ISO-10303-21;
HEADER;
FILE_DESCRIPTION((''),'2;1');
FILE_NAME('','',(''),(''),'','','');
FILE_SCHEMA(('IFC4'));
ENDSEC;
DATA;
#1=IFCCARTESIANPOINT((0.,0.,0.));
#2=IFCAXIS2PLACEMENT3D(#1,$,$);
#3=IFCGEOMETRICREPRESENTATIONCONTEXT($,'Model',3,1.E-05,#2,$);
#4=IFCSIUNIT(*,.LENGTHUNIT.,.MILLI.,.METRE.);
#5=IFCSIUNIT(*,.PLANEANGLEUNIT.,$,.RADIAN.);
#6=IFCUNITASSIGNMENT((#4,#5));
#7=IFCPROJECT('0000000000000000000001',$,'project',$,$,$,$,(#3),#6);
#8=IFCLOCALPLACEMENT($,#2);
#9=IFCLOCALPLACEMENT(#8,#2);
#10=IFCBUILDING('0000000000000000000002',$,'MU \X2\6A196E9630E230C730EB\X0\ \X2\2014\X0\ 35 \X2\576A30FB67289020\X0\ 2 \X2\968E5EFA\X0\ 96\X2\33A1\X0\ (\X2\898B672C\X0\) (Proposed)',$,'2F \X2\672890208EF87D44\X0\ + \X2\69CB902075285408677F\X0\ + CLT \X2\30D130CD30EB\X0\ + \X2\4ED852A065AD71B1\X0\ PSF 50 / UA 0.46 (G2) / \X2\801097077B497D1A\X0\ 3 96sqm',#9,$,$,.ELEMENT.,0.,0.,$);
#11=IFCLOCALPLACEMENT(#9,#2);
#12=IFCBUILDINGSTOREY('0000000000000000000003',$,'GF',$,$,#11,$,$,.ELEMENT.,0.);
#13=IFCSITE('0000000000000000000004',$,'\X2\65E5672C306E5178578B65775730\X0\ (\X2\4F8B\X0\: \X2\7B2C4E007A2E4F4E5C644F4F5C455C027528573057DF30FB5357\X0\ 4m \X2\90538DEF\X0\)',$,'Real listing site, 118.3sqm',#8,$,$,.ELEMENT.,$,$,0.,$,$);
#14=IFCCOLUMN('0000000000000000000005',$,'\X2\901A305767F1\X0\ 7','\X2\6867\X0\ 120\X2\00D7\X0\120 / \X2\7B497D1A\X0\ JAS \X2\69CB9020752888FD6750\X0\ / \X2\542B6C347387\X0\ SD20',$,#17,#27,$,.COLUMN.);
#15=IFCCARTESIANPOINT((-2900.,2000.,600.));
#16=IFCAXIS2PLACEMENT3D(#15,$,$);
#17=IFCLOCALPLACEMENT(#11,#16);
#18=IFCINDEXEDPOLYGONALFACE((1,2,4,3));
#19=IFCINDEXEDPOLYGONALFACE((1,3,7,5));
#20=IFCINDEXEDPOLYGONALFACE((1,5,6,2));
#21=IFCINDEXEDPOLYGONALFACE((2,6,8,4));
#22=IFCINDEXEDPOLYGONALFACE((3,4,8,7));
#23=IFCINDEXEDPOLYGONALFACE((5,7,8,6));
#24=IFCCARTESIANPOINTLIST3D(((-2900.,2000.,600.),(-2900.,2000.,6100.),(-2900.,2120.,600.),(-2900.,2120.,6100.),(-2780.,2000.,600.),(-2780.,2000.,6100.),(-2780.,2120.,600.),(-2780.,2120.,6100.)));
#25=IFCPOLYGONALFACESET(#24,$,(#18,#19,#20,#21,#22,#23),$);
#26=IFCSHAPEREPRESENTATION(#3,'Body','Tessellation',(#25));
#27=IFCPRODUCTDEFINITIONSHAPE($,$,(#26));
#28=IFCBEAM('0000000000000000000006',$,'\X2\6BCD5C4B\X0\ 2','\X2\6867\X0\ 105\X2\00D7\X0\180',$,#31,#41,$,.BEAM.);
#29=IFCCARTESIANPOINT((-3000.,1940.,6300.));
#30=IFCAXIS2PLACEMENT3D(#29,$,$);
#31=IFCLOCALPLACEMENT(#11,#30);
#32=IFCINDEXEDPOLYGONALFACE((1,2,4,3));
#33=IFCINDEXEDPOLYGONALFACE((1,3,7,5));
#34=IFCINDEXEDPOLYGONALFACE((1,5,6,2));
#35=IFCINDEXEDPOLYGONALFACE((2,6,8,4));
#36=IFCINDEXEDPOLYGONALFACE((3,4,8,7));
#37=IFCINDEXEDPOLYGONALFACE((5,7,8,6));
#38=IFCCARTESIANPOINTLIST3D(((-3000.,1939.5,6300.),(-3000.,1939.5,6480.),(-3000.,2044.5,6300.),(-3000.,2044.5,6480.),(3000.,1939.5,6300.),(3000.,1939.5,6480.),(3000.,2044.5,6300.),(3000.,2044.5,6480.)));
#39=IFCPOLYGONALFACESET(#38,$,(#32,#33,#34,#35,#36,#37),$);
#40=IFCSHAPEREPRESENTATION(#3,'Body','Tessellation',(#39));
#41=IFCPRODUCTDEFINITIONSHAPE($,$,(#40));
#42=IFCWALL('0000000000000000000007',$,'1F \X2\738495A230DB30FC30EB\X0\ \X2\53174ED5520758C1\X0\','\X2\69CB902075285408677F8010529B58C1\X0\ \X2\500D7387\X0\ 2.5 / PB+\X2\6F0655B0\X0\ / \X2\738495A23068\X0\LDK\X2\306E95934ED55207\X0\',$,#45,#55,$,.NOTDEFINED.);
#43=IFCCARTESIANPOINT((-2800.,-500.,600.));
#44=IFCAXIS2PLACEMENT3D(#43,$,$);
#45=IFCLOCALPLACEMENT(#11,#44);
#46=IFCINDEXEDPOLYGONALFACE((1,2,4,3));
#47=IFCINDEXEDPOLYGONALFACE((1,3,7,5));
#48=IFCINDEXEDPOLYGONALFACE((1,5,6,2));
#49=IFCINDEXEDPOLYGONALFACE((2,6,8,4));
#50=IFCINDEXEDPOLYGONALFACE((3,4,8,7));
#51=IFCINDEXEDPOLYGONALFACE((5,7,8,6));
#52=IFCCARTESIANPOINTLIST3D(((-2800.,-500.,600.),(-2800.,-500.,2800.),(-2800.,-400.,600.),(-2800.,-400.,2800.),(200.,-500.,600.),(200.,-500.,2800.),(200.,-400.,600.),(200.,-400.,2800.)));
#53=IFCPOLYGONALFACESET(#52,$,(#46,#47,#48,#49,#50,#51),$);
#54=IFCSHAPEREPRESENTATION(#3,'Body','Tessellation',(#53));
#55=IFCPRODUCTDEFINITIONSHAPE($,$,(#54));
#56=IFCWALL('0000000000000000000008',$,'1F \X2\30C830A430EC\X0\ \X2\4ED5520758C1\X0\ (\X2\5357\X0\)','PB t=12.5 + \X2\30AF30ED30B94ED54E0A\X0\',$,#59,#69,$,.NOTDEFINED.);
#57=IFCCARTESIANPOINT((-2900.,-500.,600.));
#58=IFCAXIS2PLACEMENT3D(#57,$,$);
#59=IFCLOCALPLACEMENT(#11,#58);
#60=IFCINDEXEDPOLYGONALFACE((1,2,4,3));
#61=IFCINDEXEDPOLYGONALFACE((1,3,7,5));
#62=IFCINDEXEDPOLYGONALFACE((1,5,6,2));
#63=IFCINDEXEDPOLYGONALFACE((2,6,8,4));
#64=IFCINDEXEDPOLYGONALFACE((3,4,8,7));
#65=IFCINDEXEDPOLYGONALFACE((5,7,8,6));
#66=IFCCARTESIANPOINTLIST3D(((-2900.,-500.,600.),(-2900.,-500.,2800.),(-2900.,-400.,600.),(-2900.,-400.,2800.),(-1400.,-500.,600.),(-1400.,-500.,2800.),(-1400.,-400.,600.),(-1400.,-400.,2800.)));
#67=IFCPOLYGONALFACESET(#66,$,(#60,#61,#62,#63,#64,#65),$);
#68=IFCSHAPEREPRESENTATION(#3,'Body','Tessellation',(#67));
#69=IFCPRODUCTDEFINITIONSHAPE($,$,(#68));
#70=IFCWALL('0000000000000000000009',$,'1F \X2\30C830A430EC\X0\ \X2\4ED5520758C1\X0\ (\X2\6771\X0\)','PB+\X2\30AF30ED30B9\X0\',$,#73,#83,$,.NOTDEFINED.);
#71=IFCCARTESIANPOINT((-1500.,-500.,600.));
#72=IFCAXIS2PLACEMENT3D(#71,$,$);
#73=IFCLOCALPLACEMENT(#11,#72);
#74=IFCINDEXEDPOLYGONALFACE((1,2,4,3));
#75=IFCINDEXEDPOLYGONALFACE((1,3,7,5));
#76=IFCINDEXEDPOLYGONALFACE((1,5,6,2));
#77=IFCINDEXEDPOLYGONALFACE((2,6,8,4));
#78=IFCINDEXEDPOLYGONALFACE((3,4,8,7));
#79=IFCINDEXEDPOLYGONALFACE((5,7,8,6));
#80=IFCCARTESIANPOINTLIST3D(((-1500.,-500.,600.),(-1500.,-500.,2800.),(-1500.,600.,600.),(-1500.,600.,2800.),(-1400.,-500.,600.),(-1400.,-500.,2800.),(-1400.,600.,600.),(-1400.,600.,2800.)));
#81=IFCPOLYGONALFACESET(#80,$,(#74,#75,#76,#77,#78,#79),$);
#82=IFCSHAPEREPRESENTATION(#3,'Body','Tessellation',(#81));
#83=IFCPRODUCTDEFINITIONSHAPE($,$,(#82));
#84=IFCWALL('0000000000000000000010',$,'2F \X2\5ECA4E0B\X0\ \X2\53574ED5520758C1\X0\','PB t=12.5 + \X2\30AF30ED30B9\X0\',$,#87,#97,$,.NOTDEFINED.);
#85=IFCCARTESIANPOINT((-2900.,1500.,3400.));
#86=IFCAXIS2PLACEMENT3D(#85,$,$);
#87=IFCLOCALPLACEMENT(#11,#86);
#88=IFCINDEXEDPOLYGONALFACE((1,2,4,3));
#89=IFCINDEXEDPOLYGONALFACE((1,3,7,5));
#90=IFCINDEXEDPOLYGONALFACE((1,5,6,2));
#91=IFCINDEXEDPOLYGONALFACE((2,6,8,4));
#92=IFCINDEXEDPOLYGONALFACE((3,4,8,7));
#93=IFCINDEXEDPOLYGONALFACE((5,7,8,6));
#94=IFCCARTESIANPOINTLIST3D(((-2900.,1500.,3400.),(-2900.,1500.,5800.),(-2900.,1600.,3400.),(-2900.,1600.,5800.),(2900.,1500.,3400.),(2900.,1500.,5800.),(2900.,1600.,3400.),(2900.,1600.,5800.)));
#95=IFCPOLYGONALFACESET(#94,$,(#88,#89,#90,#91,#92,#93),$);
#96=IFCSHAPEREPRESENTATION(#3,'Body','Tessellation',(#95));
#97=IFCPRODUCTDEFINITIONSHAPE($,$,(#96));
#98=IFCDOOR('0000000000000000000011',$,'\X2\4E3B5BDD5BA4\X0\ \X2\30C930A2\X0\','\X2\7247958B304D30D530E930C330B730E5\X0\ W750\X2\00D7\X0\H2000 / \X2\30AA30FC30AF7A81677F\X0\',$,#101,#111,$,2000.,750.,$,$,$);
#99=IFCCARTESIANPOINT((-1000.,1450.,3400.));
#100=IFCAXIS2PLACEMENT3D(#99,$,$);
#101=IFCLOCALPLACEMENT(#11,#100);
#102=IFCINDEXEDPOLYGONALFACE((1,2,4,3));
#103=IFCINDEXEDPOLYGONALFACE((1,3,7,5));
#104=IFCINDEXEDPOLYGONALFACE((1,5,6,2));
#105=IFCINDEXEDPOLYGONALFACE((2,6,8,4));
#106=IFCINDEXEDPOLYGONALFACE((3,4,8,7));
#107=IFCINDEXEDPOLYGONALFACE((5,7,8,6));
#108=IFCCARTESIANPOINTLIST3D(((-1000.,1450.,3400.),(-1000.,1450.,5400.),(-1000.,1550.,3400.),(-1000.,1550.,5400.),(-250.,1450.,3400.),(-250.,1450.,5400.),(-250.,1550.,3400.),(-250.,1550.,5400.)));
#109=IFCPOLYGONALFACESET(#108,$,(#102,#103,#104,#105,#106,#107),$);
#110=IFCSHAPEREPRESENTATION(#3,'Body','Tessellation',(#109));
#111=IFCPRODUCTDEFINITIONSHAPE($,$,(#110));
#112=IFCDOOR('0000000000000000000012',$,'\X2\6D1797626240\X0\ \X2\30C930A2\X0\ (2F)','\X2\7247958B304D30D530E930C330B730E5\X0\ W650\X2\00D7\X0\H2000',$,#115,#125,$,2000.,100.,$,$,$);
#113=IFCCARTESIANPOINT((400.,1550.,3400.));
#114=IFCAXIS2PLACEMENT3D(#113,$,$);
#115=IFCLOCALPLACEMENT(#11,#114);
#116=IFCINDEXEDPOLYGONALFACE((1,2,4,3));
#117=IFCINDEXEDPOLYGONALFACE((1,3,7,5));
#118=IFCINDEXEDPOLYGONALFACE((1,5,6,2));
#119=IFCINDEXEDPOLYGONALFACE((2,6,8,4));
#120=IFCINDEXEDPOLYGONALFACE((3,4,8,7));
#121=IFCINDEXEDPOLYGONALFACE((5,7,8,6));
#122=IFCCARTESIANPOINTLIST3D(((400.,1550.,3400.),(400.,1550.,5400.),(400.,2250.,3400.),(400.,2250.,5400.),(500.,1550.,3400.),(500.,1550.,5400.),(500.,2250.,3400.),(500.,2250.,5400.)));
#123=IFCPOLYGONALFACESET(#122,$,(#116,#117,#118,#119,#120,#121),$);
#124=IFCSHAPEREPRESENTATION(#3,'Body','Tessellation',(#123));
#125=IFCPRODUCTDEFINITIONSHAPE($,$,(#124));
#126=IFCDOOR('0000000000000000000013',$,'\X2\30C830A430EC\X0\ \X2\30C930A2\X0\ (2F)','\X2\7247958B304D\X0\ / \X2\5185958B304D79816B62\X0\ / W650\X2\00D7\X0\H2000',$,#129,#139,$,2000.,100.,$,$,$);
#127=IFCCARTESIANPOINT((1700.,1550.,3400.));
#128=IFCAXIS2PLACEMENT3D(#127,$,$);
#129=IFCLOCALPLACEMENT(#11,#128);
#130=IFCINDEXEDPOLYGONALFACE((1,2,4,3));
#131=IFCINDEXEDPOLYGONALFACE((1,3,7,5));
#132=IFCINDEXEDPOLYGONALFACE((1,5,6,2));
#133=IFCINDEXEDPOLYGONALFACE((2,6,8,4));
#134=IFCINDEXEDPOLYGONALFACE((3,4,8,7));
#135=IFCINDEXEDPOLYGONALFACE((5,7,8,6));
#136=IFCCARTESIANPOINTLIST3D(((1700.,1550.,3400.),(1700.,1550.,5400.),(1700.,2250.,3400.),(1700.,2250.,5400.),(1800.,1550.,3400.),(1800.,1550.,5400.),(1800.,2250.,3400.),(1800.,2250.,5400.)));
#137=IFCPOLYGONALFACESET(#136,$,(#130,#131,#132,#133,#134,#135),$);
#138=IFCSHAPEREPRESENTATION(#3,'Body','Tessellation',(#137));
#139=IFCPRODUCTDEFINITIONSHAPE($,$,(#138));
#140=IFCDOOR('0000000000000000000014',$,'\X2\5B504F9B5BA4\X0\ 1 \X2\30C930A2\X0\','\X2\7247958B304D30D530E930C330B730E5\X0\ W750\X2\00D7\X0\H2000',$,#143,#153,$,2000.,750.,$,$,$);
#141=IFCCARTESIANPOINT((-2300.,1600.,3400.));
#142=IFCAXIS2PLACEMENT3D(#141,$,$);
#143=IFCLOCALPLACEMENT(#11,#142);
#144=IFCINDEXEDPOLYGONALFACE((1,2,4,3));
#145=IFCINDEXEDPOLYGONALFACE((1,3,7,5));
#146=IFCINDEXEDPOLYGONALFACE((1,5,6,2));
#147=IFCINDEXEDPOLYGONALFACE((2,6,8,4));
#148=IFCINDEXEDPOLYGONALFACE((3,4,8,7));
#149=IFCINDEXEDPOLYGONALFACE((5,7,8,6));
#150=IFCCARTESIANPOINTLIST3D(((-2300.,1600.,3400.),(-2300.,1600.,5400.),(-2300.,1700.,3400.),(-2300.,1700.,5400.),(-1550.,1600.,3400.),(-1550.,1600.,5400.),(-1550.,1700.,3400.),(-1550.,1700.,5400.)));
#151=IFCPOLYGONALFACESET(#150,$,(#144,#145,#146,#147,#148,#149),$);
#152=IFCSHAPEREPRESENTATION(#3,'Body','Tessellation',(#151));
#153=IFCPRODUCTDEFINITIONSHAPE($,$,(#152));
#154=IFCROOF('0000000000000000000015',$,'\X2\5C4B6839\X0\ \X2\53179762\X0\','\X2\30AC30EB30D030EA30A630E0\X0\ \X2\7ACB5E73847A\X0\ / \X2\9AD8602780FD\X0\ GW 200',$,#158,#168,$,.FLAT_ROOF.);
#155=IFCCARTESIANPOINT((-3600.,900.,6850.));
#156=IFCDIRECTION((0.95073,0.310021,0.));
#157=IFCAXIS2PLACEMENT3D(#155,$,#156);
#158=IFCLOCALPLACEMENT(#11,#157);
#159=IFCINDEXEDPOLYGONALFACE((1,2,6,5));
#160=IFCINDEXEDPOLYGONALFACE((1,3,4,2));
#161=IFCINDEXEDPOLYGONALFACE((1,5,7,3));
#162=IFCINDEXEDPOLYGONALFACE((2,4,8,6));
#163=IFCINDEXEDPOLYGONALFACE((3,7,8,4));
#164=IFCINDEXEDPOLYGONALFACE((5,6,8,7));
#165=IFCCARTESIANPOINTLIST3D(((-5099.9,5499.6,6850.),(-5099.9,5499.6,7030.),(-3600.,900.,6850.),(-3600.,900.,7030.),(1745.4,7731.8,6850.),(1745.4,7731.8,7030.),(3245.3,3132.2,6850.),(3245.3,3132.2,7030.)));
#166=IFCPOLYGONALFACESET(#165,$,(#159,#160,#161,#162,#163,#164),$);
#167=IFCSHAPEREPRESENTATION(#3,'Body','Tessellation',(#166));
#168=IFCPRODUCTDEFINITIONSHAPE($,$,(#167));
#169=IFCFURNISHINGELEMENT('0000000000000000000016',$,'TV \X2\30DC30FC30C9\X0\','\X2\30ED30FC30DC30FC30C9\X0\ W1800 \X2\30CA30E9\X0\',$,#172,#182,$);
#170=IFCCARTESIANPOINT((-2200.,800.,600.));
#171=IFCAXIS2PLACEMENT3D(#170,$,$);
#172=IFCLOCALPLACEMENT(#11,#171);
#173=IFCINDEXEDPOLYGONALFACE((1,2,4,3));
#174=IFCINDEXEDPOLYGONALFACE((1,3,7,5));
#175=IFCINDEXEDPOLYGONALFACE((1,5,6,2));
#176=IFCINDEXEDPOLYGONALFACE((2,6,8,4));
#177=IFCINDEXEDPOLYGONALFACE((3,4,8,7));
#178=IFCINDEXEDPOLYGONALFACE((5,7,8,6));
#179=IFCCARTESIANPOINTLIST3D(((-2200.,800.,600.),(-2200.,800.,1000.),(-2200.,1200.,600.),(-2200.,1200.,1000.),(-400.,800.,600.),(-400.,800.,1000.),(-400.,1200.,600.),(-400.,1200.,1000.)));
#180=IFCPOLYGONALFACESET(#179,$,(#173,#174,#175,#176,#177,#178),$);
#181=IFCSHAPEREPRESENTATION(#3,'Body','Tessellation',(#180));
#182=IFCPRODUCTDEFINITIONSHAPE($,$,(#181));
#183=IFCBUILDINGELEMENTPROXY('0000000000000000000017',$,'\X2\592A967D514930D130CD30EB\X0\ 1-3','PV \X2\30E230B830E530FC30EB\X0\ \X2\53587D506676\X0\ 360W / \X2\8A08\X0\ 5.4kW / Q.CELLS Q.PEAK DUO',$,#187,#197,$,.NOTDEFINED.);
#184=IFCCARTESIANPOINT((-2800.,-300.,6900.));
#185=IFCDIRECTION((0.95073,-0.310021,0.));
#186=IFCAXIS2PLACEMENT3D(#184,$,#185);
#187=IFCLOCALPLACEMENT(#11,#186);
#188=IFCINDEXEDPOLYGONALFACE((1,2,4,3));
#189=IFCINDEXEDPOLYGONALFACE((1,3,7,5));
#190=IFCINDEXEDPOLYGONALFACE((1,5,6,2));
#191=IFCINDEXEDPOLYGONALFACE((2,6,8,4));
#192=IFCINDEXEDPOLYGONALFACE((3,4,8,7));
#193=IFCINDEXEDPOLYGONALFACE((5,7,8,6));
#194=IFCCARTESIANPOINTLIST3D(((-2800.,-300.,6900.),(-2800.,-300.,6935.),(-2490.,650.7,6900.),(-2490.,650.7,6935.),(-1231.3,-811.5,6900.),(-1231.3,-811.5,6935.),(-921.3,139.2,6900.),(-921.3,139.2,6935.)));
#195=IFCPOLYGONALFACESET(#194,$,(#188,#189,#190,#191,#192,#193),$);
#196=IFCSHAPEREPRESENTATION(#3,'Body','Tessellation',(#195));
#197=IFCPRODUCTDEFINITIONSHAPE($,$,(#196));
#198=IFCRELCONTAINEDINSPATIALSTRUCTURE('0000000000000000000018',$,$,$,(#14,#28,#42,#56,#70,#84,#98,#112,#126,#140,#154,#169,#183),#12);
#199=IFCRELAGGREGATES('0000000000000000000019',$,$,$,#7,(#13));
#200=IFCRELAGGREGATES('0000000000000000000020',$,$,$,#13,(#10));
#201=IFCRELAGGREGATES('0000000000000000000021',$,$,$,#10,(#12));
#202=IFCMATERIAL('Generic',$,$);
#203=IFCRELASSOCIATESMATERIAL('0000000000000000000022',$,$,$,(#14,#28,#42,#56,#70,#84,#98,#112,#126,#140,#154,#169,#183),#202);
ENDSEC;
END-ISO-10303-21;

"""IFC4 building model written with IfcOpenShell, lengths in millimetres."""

from ifc_helpers import new_model, si_unit, frame, frame_2d, origin, place, context, project, spatial, rectangle, extrude, material, element, fill, save


model = new_model("IFC4")

# Units and contexts
model_context = context("Model", 3, precision=1e-05, world=origin())
ifc_project = project(units=[si_unit("LENGTHUNIT", "METRE", prefix="MILLI"), si_unit("PLANEANGLEUNIT", "RADIAN")], contexts=[model_context])

# Site, building, storey
site_placement = place(None, origin())
site = spatial("IfcSite", under=ifc_project, at=site_placement, Name="日本の典型敷地 (例: 第一種低層住居専用地域・南 4m 道路)", ObjectType="Real listing site, 118.3sqm", CompositionType="ELEMENT", RefElevation=0.0)
building_placement = place(site_placement, origin())
building = spatial("IfcBuilding", under=site, at=building_placement, Name="MU 標準モデル — 35 坪・木造 2 階建 96㎡ (見本) (Proposed)", ObjectType="2F 木造軸組 + 構造用合板 + CLT パネル + 付加断熱 PSF 50 / UA 0.46 (G2) / 耐震等級 3 96sqm", CompositionType="ELEMENT", ElevationOfRefHeight=0.0, ElevationOfTerrain=0.0)
storey_placement = place(building_placement, origin())
storey = spatial("IfcBuildingStorey", under=building, at=storey_placement, Name="GF", CompositionType="ELEMENT", Elevation=0.0)

# Column
ifc_material_1 = material(Name="Generic")
column_placement = place(storey_placement, frame((-2900.0, 2000.0, 600.0)))
element("IfcColumn", 1, at=column_placement, inside=storey, material=ifc_material_1, Name="通し柱 7", Description="桧 120×120 / 等級 JAS 構造用製材 / 含水率 SD20", PredefinedType="COLUMN", context=model_context, shape_type="SweptSolid", body=[
    extrude(rectangle(XDim=120.0, YDim=120.0, at=frame_2d((60.0, 60.0))), frame((-2900.0, 2000.0, 600.0)), (0.0, 0.0, 1.0), 5500.0),
])

# Beam
beam_1_placement = place(storey_placement, frame((-3000.0, 1940.0, 6300.0)))
element("IfcBeam", 2, at=beam_1_placement, inside=storey, material=ifc_material_1, Name="母屋 2", Description="桧 105×180", PredefinedType="BEAM", context=model_context, shape_type="SweptSolid", body=[
    extrude(rectangle(XDim=6000.0, YDim=105.0, at=frame_2d((3000.0, 52.0))), frame((-3000.0, 1940.0, 6300.0)), (0.0, 0.0, 1.0), 180.0),
])

# Walls
wall_1_placement = place(storey_placement, frame((-2800.0, -500.0, 600.0)))
element("IfcWall", 3, at=wall_1_placement, inside=storey, material=ifc_material_1, Name="1F 玄関ホール 北仕切壁", Description="構造用合板耐力壁 倍率 2.5 / PB+漆喰 / 玄関とLDKの間仕切", PredefinedType="NOTDEFINED", context=model_context, shape_type="SweptSolid", body=[
    extrude(rectangle(XDim=3000.0, YDim=100.0, at=frame_2d((1500.0, 50.0))), frame((-2800.0, -500.0, 600.0)), (0.0, 0.0, 1.0), 2200.0),
])
wall_2_placement = place(storey_placement, frame((-2900.0, -500.0, 600.0)))
element("IfcWall", 4, at=wall_2_placement, inside=storey, material=ifc_material_1, Name="1F トイレ 仕切壁 (南)", Description="PB t=12.5 + クロス仕上", PredefinedType="NOTDEFINED", context=model_context, shape_type="SweptSolid", body=[
    extrude(rectangle(XDim=1500.0, YDim=100.0, at=frame_2d((750.0, 50.0))), frame((-2900.0, -500.0, 600.0)), (0.0, 0.0, 1.0), 2200.0),
])
wall_3_placement = place(storey_placement, frame((-1500.0, -500.0, 600.0)))
element("IfcWall", 5, at=wall_3_placement, inside=storey, material=ifc_material_1, Name="1F トイレ 仕切壁 (東)", Description="PB+クロス", PredefinedType="NOTDEFINED", context=model_context, shape_type="SweptSolid", body=[
    extrude(rectangle(XDim=100.0, YDim=1100.0, at=frame_2d((50.0, 550.0))), frame((-1500.0, -500.0, 600.0)), (0.0, 0.0, 1.0), 2200.0),
])

# Wall, openings, doors
wall_4_placement = place(storey_placement, frame((-2900.0, 1500.0, 3400.0)))
wall_4 = element("IfcWall", 6, at=wall_4_placement, inside=storey, material=ifc_material_1, Name="2F 廊下 南仕切壁", Description="PB t=12.5 + クロス", PredefinedType="NOTDEFINED", context=model_context, shape_type="SweptSolid", body=[
    extrude(rectangle(XDim=5800.0, YDim=100.0, at=frame_2d((2900.0, 50.0))), frame((-2900.0, 1500.0, 3400.0)), (0.0, 0.0, 1.0), 2400.0),
])
opening_1_placement = place(storey_placement, frame((-1000.0, 1450.0, 3400.0)))
opening_1 = element("IfcOpeningElement", 7, at=opening_1_placement, cuts=wall_4, PredefinedType="NOTDEFINED", context=model_context, shape_type="SweptSolid", body=[
    extrude(rectangle(XDim=750.0, YDim=100.0, at=frame_2d((375.0, 50.0))), frame((-1000.0, 1450.0, 3400.0)), (0.0, 0.0, 1.0), 2000.0),
])
opening_2_placement = place(storey_placement, frame((400.0, 1550.0, 3400.0)))
opening_2 = element("IfcOpeningElement", 8, at=opening_2_placement, cuts=wall_4, PredefinedType="NOTDEFINED", context=model_context, shape_type="SweptSolid", body=[
    extrude(rectangle(XDim=100.0, YDim=700.0, at=frame_2d((50.0, 350.0))), frame((400.0, 1550.0, 3400.0)), (0.0, 0.0, 1.0), 2000.0),
])
opening_3_placement = place(storey_placement, frame((1700.0, 1550.0, 3400.0)))
opening_3 = element("IfcOpeningElement", 9, at=opening_3_placement, cuts=wall_4, PredefinedType="NOTDEFINED", context=model_context, shape_type="SweptSolid", body=[
    extrude(rectangle(XDim=100.0, YDim=700.0, at=frame_2d((50.0, 350.0))), frame((1700.0, 1550.0, 3400.0)), (0.0, 0.0, 1.0), 2000.0),
])
door_1_placement = place(storey_placement, frame((-1000.0, 1450.0, 3400.0)))
door_1 = element("IfcDoor", 10, at=door_1_placement, inside=storey, material=ifc_material_1, Name="主寝室 ドア", Description="片開きフラッシュ W750×H2000 / オーク突板", OverallHeight=2000.0, OverallWidth=750.0, context=model_context, shape_type="SweptSolid", body=[
    extrude(rectangle(XDim=750.0, YDim=100.0, at=frame_2d((375.0, 50.0))), frame((-1000.0, 1450.0, 3400.0)), (0.0, 0.0, 1.0), 2000.0),
])
fill(opening_1, door_1)
door_2_placement = place(storey_placement, frame((400.0, 1550.0, 3400.0)))
door_2 = element("IfcDoor", 11, at=door_2_placement, inside=storey, material=ifc_material_1, Name="洗面所 ドア (2F)", Description="片開きフラッシュ W650×H2000", OverallHeight=2000.0, OverallWidth=100.0, context=model_context, shape_type="SweptSolid", body=[
    extrude(rectangle(XDim=100.0, YDim=700.0, at=frame_2d((50.0, 350.0))), frame((400.0, 1550.0, 3400.0)), (0.0, 0.0, 1.0), 2000.0),
])
fill(opening_2, door_2)
door_3_placement = place(storey_placement, frame((1700.0, 1550.0, 3400.0)))
door_3 = element("IfcDoor", 12, at=door_3_placement, inside=storey, material=ifc_material_1, Name="トイレ ドア (2F)", Description="片開き / 内開き禁止 / W650×H2000", OverallHeight=2000.0, OverallWidth=100.0, context=model_context, shape_type="SweptSolid", body=[
    extrude(rectangle(XDim=100.0, YDim=700.0, at=frame_2d((50.0, 350.0))), frame((1700.0, 1550.0, 3400.0)), (0.0, 0.0, 1.0), 2000.0),
])
fill(opening_3, door_3)

# Door
door_4_placement = place(storey_placement, frame((-2300.0, 1600.0, 3400.0)))
element("IfcDoor", 13, at=door_4_placement, inside=storey, material=ifc_material_1, Name="子供室 1 ドア", Description="片開きフラッシュ W750×H2000", OverallHeight=2000.0, OverallWidth=750.0, context=model_context, shape_type="SweptSolid", body=[
    extrude(rectangle(XDim=750.0, YDim=100.0, at=frame_2d((375.0, 50.0))), frame((-2300.0, 1600.0, 3400.0)), (0.0, 0.0, 1.0), 2000.0),
])

# Roof
roof_1_placement = place(storey_placement, frame((-3600.0, 900.0, 6850.0), x_axis=(0.95073, 0.310021, 0.0)))
element("IfcRoof", 14, at=roof_1_placement, inside=storey, material=ifc_material_1, Name="屋根 北面", Description="ガルバリウム 立平葺 / 高性能 GW 200", PredefinedType="FLAT_ROOF", context=model_context, shape_type="SweptSolid", body=[
    extrude(rectangle(XDim=7200.0, YDim=4838.0, at=frame_2d((3600.0, 2419.0))), frame((-3600.0, 900.0, 6850.0), x_axis=(0.95073, 0.310021, 0.0)), (0.0, 0.0, 1.0), 180.0),
])

# Furnishing element
furnishing_1_placement = place(storey_placement, frame((-2200.0, 800.0, 600.0)))
element("IfcFurnishingElement", 15, at=furnishing_1_placement, inside=storey, material=ifc_material_1, Name="TV ボード", Description="ローボード W1800 ナラ", context=model_context, shape_type="SweptSolid", body=[
    extrude(rectangle(XDim=1800.0, YDim=400.0, at=frame_2d((900.0, 200.0))), frame((-2200.0, 800.0, 600.0)), (0.0, 0.0, 1.0), 400.0),
])

# Building element proxy
proxy_1_placement = place(storey_placement, frame((-2800.0, -300.0, 6900.0), x_axis=(0.95073, -0.310021, 0.0)))
element("IfcBuildingElementProxy", 16, at=proxy_1_placement, inside=storey, material=ifc_material_1, Name="太陽光パネル 1-3", Description="PV モジュール 単結晶 360W / 計 5.4kW / Q.CELLS Q.PEAK DUO", PredefinedType="NOTDEFINED", context=model_context, shape_type="SweptSolid", body=[
    extrude(rectangle(XDim=1650.0, YDim=1000.0, at=frame_2d((825.0, 500.0))), frame((-2800.0, -300.0, 6900.0), x_axis=(0.95073, -0.310021, 0.0)), (0.0, 0.0, 1.0), 35.0),
])

save(model, "model.ifc")
